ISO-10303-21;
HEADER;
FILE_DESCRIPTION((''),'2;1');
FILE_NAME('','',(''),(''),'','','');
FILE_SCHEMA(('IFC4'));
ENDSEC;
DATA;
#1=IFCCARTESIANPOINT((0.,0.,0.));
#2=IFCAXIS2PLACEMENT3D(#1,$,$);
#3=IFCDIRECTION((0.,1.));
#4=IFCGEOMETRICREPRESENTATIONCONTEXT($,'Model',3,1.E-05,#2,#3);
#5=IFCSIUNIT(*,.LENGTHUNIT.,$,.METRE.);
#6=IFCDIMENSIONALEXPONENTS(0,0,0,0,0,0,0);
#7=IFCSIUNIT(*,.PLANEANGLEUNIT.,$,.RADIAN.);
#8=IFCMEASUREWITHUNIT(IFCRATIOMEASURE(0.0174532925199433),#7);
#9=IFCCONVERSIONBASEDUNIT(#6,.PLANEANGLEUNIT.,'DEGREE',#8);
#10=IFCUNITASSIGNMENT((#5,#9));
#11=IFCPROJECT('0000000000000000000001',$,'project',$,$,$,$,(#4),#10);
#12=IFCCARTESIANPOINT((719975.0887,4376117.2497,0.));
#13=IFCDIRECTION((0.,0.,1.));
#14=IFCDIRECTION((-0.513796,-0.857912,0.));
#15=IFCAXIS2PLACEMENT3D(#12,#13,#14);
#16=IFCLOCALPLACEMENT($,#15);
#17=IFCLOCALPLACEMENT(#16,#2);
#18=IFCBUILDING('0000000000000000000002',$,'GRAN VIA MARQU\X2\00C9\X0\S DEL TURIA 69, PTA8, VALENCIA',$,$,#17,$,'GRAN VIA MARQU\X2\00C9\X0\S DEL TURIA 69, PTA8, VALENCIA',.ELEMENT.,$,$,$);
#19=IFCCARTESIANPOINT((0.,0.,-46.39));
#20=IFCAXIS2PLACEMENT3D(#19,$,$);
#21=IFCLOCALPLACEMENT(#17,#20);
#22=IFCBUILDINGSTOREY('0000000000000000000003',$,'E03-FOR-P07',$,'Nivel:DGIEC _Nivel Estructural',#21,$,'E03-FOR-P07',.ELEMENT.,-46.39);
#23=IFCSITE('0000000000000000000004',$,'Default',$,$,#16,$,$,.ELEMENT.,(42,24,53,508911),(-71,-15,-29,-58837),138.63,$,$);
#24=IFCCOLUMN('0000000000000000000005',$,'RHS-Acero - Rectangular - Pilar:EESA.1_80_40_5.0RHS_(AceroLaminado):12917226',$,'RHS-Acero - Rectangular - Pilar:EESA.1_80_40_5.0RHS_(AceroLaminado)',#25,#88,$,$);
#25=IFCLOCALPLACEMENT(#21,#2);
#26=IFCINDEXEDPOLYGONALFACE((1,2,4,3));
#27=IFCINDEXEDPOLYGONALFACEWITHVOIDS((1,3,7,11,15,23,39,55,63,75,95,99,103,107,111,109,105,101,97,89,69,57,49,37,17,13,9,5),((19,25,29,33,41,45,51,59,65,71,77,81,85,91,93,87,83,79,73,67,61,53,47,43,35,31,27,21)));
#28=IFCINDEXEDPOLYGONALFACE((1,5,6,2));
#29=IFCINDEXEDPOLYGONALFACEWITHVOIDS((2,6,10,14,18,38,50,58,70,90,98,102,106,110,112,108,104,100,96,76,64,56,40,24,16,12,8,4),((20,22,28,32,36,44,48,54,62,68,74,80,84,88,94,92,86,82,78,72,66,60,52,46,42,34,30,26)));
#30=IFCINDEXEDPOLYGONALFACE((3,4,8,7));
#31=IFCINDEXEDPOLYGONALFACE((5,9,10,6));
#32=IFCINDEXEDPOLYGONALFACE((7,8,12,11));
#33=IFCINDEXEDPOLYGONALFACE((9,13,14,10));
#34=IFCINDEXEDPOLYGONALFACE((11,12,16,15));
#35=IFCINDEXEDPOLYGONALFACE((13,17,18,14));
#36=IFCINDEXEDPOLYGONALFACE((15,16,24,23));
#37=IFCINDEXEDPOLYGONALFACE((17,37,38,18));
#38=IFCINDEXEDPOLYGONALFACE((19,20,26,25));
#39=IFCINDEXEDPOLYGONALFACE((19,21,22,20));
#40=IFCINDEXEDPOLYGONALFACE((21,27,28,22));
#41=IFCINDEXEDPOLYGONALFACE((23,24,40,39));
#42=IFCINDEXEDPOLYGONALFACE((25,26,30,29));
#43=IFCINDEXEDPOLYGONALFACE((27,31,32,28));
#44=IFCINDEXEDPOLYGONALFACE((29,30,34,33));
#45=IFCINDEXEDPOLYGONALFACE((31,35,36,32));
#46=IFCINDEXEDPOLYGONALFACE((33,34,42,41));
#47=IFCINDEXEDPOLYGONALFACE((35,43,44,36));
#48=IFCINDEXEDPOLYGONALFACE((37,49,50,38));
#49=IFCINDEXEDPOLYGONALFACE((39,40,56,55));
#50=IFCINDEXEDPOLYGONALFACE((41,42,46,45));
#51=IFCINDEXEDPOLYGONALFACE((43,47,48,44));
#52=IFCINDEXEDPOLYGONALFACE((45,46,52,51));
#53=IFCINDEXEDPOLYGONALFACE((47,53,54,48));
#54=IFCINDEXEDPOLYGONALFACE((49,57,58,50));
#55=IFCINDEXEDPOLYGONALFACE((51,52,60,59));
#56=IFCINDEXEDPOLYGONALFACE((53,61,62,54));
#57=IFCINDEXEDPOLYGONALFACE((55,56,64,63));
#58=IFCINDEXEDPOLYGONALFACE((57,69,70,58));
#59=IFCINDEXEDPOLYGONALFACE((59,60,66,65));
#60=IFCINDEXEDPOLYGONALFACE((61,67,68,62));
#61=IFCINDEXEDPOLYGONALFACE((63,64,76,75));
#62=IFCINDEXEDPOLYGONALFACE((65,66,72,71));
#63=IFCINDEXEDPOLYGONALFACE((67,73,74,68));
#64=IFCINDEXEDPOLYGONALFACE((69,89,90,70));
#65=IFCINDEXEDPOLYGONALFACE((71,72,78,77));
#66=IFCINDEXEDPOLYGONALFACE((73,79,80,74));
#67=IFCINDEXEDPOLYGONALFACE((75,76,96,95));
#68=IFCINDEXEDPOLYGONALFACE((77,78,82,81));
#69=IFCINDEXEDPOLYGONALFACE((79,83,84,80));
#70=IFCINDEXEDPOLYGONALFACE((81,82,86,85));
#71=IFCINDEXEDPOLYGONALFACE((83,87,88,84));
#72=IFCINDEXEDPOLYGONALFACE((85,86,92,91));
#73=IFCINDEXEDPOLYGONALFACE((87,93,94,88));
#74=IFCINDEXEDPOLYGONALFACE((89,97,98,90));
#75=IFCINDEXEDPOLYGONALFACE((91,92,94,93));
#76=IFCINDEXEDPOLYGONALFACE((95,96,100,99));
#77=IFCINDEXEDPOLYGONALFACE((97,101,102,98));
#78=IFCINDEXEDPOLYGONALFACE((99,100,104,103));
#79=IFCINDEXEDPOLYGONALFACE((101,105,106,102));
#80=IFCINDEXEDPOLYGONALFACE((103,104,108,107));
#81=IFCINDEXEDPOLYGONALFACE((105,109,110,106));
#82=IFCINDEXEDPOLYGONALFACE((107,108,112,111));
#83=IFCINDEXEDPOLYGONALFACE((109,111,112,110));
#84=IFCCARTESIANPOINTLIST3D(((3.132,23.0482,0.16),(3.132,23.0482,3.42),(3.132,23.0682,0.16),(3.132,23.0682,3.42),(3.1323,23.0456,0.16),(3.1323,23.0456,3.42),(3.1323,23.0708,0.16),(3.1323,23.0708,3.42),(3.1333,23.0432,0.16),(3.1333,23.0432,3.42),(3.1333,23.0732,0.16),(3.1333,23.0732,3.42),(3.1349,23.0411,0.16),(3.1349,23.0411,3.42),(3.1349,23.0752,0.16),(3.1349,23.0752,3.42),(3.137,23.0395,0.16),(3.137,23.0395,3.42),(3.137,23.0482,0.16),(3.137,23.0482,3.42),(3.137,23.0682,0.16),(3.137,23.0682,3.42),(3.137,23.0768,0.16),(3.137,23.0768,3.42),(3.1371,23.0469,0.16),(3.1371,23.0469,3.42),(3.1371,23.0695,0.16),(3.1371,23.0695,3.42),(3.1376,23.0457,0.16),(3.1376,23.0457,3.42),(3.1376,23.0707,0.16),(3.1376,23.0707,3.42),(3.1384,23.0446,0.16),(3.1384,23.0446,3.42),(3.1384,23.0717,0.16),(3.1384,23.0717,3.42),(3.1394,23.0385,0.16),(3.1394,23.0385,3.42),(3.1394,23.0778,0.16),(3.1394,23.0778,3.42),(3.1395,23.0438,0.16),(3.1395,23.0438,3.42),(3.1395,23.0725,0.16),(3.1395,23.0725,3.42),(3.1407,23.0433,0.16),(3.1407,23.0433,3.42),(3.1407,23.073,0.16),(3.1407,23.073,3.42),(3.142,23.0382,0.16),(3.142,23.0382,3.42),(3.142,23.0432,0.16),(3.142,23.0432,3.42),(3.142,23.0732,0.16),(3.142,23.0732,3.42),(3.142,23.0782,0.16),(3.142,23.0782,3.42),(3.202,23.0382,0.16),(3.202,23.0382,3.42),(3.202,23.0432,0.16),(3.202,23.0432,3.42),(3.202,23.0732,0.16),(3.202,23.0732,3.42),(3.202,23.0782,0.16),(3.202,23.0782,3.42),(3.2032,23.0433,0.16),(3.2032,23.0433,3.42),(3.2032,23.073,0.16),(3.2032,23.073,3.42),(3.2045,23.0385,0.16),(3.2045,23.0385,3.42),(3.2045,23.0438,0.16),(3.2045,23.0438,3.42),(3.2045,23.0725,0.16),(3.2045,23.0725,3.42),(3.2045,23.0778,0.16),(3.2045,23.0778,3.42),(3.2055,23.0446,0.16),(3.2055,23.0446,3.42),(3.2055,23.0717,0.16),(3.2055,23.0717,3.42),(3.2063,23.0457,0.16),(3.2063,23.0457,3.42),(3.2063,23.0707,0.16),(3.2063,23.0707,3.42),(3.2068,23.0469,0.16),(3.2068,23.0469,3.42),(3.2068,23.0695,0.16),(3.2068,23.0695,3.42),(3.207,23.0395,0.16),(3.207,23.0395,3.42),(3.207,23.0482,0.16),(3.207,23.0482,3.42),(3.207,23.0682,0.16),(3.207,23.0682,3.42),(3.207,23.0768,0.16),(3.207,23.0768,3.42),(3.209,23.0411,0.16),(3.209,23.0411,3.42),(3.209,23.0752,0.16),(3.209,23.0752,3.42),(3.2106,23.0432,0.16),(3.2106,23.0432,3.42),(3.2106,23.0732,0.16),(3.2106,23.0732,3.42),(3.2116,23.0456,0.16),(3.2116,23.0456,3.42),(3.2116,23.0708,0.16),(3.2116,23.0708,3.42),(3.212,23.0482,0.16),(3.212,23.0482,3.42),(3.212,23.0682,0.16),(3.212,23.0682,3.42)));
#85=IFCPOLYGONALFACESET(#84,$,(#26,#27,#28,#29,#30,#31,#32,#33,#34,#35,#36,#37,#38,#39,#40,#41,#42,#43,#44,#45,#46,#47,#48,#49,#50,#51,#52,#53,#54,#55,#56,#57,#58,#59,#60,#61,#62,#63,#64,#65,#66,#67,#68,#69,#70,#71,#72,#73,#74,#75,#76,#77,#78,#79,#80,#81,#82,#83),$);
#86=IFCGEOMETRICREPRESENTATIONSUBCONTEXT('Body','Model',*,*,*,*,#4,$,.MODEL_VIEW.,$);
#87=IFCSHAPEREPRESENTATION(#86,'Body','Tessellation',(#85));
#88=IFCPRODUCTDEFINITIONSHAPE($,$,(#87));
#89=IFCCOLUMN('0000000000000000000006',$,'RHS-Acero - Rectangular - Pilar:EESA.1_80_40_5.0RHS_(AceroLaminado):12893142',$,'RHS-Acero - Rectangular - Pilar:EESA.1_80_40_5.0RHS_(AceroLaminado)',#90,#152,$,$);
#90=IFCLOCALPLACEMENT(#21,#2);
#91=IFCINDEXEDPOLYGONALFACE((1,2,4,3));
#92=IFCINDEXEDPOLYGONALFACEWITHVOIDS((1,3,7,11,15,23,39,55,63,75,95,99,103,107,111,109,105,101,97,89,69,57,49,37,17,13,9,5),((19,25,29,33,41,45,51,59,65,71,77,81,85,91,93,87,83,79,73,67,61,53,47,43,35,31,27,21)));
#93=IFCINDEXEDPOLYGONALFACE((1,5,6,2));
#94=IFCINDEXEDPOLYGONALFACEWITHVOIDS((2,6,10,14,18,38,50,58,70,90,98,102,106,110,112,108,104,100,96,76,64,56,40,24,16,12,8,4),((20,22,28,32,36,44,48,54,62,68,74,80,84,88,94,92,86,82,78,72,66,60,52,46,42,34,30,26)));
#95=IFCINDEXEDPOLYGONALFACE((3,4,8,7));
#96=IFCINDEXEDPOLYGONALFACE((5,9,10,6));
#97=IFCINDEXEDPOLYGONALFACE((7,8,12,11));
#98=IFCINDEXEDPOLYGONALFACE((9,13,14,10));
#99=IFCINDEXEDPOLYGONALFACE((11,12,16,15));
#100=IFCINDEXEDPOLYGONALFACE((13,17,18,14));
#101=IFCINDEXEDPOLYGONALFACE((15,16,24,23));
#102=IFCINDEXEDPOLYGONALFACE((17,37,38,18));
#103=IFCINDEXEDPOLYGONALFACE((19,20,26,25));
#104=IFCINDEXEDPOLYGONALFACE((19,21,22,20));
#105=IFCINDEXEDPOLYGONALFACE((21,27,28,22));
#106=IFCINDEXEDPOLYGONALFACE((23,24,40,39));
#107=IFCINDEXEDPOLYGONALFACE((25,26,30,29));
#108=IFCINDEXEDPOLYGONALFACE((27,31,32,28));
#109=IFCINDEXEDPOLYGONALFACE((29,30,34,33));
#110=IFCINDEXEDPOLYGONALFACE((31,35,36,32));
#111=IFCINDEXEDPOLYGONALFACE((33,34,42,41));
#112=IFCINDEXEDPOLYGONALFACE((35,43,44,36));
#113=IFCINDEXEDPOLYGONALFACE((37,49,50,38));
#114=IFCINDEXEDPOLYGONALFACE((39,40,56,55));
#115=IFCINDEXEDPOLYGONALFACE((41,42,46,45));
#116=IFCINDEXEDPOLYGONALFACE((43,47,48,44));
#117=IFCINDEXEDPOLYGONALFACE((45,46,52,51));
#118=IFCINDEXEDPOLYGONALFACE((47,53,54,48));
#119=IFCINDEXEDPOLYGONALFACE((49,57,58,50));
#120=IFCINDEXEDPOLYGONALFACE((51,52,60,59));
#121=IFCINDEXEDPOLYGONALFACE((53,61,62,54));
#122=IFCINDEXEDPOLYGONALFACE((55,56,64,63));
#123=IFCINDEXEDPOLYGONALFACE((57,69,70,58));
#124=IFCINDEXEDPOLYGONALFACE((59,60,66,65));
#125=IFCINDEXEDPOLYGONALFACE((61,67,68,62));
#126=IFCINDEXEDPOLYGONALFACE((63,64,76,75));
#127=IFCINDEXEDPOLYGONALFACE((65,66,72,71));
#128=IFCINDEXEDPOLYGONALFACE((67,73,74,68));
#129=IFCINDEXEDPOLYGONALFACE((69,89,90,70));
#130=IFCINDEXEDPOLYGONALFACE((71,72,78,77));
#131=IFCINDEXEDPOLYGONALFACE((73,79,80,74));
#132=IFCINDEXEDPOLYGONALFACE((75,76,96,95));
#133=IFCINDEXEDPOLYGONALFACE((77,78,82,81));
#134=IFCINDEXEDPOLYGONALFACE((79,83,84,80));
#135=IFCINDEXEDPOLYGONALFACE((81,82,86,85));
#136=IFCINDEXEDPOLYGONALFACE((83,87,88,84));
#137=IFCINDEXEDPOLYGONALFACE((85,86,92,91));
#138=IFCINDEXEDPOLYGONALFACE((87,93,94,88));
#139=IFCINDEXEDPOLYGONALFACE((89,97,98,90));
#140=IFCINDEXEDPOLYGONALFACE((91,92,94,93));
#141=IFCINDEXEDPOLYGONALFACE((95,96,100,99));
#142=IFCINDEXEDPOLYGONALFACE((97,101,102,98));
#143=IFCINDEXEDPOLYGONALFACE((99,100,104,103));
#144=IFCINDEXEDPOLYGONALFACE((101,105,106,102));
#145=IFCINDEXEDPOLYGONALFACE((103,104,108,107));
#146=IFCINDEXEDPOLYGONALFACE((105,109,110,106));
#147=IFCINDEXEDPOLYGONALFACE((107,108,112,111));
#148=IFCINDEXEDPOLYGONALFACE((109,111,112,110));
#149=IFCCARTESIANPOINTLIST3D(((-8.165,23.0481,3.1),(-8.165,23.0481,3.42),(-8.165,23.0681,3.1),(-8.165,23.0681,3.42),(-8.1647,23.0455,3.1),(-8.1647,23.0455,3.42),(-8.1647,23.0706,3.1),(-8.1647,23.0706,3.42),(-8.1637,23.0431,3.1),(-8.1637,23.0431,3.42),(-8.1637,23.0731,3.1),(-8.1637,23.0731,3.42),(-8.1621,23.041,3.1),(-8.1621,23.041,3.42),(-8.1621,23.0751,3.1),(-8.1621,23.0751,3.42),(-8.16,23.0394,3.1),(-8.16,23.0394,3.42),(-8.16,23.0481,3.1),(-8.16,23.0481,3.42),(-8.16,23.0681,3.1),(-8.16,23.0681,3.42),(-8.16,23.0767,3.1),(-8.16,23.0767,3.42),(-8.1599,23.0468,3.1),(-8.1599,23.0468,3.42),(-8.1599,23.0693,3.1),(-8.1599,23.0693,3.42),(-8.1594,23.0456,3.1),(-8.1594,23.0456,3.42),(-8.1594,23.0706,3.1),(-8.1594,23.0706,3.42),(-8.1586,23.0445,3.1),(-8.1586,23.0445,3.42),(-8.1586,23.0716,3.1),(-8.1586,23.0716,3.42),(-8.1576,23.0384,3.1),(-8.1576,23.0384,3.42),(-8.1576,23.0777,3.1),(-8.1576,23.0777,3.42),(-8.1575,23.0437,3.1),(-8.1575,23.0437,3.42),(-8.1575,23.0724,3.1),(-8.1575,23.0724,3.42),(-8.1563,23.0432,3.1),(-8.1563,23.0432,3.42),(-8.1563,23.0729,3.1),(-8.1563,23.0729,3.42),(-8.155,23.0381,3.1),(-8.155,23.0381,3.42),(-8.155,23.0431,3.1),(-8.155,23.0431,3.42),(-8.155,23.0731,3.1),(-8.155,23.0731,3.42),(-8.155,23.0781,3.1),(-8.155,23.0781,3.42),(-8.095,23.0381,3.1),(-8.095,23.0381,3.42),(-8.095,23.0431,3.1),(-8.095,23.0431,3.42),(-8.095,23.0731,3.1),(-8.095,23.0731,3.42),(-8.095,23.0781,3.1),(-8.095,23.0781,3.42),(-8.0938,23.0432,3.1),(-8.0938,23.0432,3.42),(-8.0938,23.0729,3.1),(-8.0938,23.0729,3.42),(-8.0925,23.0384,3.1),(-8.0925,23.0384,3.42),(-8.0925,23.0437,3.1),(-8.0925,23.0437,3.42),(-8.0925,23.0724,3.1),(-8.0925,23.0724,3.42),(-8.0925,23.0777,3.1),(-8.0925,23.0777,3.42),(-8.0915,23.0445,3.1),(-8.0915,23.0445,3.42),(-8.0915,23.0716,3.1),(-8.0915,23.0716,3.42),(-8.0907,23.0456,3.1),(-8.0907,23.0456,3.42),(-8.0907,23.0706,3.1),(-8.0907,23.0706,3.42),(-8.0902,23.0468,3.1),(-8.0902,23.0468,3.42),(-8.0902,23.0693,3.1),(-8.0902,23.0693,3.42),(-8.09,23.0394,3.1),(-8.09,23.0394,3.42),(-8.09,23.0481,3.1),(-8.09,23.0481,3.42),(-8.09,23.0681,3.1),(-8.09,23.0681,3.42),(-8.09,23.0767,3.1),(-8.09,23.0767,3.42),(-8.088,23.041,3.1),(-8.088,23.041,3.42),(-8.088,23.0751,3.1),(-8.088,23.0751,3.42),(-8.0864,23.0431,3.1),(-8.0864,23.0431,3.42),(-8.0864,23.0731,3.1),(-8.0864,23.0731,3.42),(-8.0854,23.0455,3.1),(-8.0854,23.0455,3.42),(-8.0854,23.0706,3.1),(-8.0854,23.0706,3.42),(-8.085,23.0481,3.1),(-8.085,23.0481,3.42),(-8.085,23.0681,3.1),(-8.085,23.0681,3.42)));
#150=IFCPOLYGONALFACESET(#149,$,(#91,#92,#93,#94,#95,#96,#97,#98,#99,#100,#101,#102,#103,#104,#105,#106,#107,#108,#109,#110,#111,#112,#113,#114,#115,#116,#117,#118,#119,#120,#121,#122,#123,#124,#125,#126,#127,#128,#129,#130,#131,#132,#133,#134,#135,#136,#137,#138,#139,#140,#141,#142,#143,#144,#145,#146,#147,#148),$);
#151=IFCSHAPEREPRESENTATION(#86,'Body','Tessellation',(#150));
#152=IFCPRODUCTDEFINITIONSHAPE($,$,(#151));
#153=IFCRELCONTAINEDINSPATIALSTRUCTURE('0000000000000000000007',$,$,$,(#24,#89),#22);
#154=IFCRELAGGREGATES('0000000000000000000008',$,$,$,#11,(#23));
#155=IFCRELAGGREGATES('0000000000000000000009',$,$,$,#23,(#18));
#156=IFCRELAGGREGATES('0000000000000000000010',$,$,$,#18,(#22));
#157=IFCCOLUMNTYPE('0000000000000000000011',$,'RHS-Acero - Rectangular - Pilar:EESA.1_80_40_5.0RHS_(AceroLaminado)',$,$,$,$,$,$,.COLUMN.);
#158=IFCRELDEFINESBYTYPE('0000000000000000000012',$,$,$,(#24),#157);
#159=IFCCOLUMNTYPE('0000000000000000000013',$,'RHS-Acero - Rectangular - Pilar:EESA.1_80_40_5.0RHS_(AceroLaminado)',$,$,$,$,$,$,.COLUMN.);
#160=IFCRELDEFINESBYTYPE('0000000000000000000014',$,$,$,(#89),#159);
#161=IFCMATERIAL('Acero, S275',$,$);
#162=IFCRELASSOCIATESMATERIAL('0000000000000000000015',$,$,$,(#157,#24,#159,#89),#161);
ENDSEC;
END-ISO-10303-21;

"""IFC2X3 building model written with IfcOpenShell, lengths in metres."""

from ifc_helpers import new_model, entity, si_unit, converted_unit, direction, frame, frame_2d, origin, place, context, subcontext, project, spatial, polyline, circle_curve, parameter, trimmed, segment, composite_curve, outline, extrude, source, transform, mapped, material, type_object, type_shapes, element, save


model = new_model("IFC2X3")

# Units and contexts
model_context = context("Model", 3, precision=1e-05, world=origin(), true_north=direction((0.0, 1.0)))
body_context = subcontext(model_context, "Body", "Model", "MODEL_VIEW")
ifc_project = project(units=[si_unit("LENGTHUNIT", "METRE"), converted_unit("PLANEANGLEUNIT", "DEGREE", entity("IfcRatioMeasure", 0.0174532925199433), si_unit("PLANEANGLEUNIT", "RADIAN"), dimensions=[0, 0, 0, 0, 0, 0, 0])], contexts=[model_context])

# Site, building, storey
site_placement = place(None, frame((719975.0887, 4376117.2497, 0.0), z_axis=(0.0, 0.0, 1.0), x_axis=(-0.513796, -0.857912, 0.0)))
site = spatial("IfcSite", under=ifc_project, at=site_placement, Name="Default", CompositionType="ELEMENT", RefLatitude=(42, 24, 53, 508911), RefLongitude=(-71, -15, -29, -58837), RefElevation=138.63)
building_placement = place(site_placement, origin())
building = spatial("IfcBuilding", under=site, at=building_placement, Name="GRAN VIA MARQUÉS DEL TURIA 69, PTA8, VALENCIA", LongName="GRAN VIA MARQUÉS DEL TURIA 69, PTA8, VALENCIA", CompositionType="ELEMENT")
storey_placement = place(building_placement, frame((0.0, 0.0, -46.39)))
storey = spatial("IfcBuildingStorey", under=building, at=storey_placement, Name="E03-FOR-P07", ObjectType="Nivel:DGIEC _Nivel Estructural", LongName="E03-FOR-P07", CompositionType="ELEMENT", Elevation=-46.39)

# Columns
ifc_material = material(Name="Acero, S275")
column_type_1 = type_object("IfcColumnType", Name="RHS-Acero - Rectangular - Pilar:EESA.1_80_40_5.0RHS_(AceroLaminado)", PredefinedType="COLUMN", material=ifc_material)
shared_shape_1 = source(origin(), body_context, "Body", "SweptSolid", [
    extrude(outline(composite_curve([segment(polyline([(-0.01, -0.04), (0.01, -0.04)]), True, "CONTINUOUS"), segment(trimmed(circle_curve(frame_2d((0.01, -0.03), x_axis=(-1.0, 0.0)), 0.01), [parameter(90.0)], [parameter(180.0)], True, "PARAMETER"), True, "CONTINUOUS"), segment(polyline([(0.02, -0.03), (0.02, 0.03)]), True, "CONTINUOUS"), segment(trimmed(circle_curve(frame_2d((0.01, 0.03), x_axis=(-1.0, 0.0)), 0.01), [parameter(180.0)], [parameter(270.0)], True, "PARAMETER"), True, "CONTINUOUS"), segment(polyline([(0.01, 0.04), (-0.01, 0.04)]), True, "CONTINUOUS"), segment(trimmed(circle_curve(frame_2d((-0.01, 0.03), x_axis=(-1.0, 0.0)), 0.01), [parameter(270.0)], [parameter(360.0)], True, "PARAMETER"), True, "CONTINUOUS"), segment(polyline([(-0.02, 0.03), (-0.02, -0.03)]), True, "CONTINUOUS"), segment(trimmed(circle_curve(frame_2d((-0.01, -0.03), x_axis=(-1.0, 0.0)), 0.01), [parameter(360.0)], [parameter(90.0)], True, "PARAMETER"), True, "CONTINUOUS")], self_intersect=False), holes=[composite_curve([segment(trimmed(circle_curve(frame_2d((-0.01, -0.03), x_axis=(-1.0, 0.0)), 0.005), [parameter(0.0)], [parameter(90.0)], True, "PARAMETER"), False, "CONTINUOUS"), segment(polyline([(-0.015, -0.03), (-0.015, 0.03)]), True, "CONTINUOUS"), segment(trimmed(circle_curve(frame_2d((-0.01, 0.03), x_axis=(-1.0, 0.0)), 0.005), [parameter(270.0)], [parameter(0.0)], True, "PARAMETER"), False, "CONTINUOUS"), segment(polyline([(-0.01, 0.035), (0.01, 0.035)]), True, "CONTINUOUS"), segment(trimmed(circle_curve(frame_2d((0.01, 0.03), x_axis=(-1.0, 0.0)), 0.005), [parameter(180.0)], [parameter(270.0)], True, "PARAMETER"), False, "CONTINUOUS"), segment(polyline([(0.015, 0.03), (0.015, -0.03)]), True, "CONTINUOUS"), segment(trimmed(circle_curve(frame_2d((0.01, -0.03), x_axis=(-1.0, 0.0)), 0.005), [parameter(90.0)], [parameter(180.0)], True, "PARAMETER"), False, "CONTINUOUS"), segment(polyline([(0.01, -0.035), (-0.01, -0.035)]), True, "CONTINUOUS")], self_intersect=False)]), frame((0.0, 0.0, -46.23), z_axis=(0.0, 0.0, 1.0), x_axis=(-1.0, 0.0, 0.0)), (0.0, 0.0, 1.0), 3.26),
])
type_shapes(column_type_1, [shared_shape_1])
for number, where, z_axis, x_axis, name in (
    (1, (3.172, 23.0582, 46.39), (0.0, 0.0, 1.0), (0.0, 1.0, 0.0), "RHS-Acero - Rectangular - Pilar:EESA.1_80_40_5.0RHS_(AceroLaminado):12917226"),
):
    element("IfcColumn", number, at=place(storey_placement, frame(where, z_axis=z_axis, x_axis=x_axis)), inside=storey, type_object=column_type_1, material=ifc_material, Name=name, ObjectType="RHS-Acero - Rectangular - Pilar:EESA.1_80_40_5.0RHS_(AceroLaminado)", context=body_context, shape_type="MappedRepresentation", body=[
        mapped(shared_shape_1, transform((0.0, 0.0, 0.0), scale=1.0)),
    ])
column_type_2 = type_object("IfcColumnType", Name="RHS-Acero - Rectangular - Pilar:EESA.1_80_40_5.0RHS_(AceroLaminado)", PredefinedType="COLUMN", material=ifc_material)
shared_shape_2 = source(origin(), body_context, "Body", "SweptSolid", [
    extrude(outline(composite_curve([segment(polyline([(-0.01, -0.04), (0.01, -0.04)]), True, "CONTINUOUS"), segment(trimmed(circle_curve(frame_2d((0.01, -0.03), x_axis=(-1.0, 0.0)), 0.01), [parameter(90.0)], [parameter(180.0)], True, "PARAMETER"), True, "CONTINUOUS"), segment(polyline([(0.02, -0.03), (0.02, 0.03)]), True, "CONTINUOUS"), segment(trimmed(circle_curve(frame_2d((0.01, 0.03), x_axis=(-1.0, 0.0)), 0.01), [parameter(180.0)], [parameter(270.0)], True, "PARAMETER"), True, "CONTINUOUS"), segment(polyline([(0.01, 0.04), (-0.01, 0.04)]), True, "CONTINUOUS"), segment(trimmed(circle_curve(frame_2d((-0.01, 0.03), x_axis=(-1.0, 0.0)), 0.01), [parameter(270.0)], [parameter(360.0)], True, "PARAMETER"), True, "CONTINUOUS"), segment(polyline([(-0.02, 0.03), (-0.02, -0.03)]), True, "CONTINUOUS"), segment(trimmed(circle_curve(frame_2d((-0.01, -0.03), x_axis=(-1.0, 0.0)), 0.01), [parameter(360.0)], [parameter(90.0)], True, "PARAMETER"), True, "CONTINUOUS")], self_intersect=False), holes=[composite_curve([segment(trimmed(circle_curve(frame_2d((-0.01, -0.03), x_axis=(-1.0, 0.0)), 0.005), [parameter(0.0)], [parameter(90.0)], True, "PARAMETER"), False, "CONTINUOUS"), segment(polyline([(-0.015, -0.03), (-0.015, 0.03)]), True, "CONTINUOUS"), segment(trimmed(circle_curve(frame_2d((-0.01, 0.03), x_axis=(-1.0, 0.0)), 0.005), [parameter(270.0)], [parameter(0.0)], True, "PARAMETER"), False, "CONTINUOUS"), segment(polyline([(-0.01, 0.035), (0.01, 0.035)]), True, "CONTINUOUS"), segment(trimmed(circle_curve(frame_2d((0.01, 0.03), x_axis=(-1.0, 0.0)), 0.005), [parameter(180.0)], [parameter(270.0)], True, "PARAMETER"), False, "CONTINUOUS"), segment(polyline([(0.015, 0.03), (0.015, -0.03)]), True, "CONTINUOUS"), segment(trimmed(circle_curve(frame_2d((0.01, -0.03), x_axis=(-1.0, 0.0)), 0.005), [parameter(90.0)], [parameter(180.0)], True, "PARAMETER"), False, "CONTINUOUS"), segment(polyline([(0.01, -0.035), (-0.01, -0.035)]), True, "CONTINUOUS")], self_intersect=False)]), frame((0.0, 0.0, -43.29), z_axis=(0.0, 0.0, 1.0), x_axis=(-1.0, 0.0, 0.0)), (0.0, 0.0, 1.0), 0.32),
])
type_shapes(column_type_2, [shared_shape_2])
column_1_placement = place(storey_placement, frame((-8.125, 23.0581, 46.39), z_axis=(0.0, 0.0, 1.0), x_axis=(0.0, 1.0, 0.0)))
element("IfcColumn", 2, at=column_1_placement, inside=storey, type_object=column_type_2, material=ifc_material, Name="RHS-Acero - Rectangular - Pilar:EESA.1_80_40_5.0RHS_(AceroLaminado):12893142", ObjectType="RHS-Acero - Rectangular - Pilar:EESA.1_80_40_5.0RHS_(AceroLaminado)", context=body_context, shape_type="MappedRepresentation", body=[
    mapped(shared_shape_2, transform((0.0, 0.0, 0.0), scale=1.0)),
])

save(model, "model.ifc")
